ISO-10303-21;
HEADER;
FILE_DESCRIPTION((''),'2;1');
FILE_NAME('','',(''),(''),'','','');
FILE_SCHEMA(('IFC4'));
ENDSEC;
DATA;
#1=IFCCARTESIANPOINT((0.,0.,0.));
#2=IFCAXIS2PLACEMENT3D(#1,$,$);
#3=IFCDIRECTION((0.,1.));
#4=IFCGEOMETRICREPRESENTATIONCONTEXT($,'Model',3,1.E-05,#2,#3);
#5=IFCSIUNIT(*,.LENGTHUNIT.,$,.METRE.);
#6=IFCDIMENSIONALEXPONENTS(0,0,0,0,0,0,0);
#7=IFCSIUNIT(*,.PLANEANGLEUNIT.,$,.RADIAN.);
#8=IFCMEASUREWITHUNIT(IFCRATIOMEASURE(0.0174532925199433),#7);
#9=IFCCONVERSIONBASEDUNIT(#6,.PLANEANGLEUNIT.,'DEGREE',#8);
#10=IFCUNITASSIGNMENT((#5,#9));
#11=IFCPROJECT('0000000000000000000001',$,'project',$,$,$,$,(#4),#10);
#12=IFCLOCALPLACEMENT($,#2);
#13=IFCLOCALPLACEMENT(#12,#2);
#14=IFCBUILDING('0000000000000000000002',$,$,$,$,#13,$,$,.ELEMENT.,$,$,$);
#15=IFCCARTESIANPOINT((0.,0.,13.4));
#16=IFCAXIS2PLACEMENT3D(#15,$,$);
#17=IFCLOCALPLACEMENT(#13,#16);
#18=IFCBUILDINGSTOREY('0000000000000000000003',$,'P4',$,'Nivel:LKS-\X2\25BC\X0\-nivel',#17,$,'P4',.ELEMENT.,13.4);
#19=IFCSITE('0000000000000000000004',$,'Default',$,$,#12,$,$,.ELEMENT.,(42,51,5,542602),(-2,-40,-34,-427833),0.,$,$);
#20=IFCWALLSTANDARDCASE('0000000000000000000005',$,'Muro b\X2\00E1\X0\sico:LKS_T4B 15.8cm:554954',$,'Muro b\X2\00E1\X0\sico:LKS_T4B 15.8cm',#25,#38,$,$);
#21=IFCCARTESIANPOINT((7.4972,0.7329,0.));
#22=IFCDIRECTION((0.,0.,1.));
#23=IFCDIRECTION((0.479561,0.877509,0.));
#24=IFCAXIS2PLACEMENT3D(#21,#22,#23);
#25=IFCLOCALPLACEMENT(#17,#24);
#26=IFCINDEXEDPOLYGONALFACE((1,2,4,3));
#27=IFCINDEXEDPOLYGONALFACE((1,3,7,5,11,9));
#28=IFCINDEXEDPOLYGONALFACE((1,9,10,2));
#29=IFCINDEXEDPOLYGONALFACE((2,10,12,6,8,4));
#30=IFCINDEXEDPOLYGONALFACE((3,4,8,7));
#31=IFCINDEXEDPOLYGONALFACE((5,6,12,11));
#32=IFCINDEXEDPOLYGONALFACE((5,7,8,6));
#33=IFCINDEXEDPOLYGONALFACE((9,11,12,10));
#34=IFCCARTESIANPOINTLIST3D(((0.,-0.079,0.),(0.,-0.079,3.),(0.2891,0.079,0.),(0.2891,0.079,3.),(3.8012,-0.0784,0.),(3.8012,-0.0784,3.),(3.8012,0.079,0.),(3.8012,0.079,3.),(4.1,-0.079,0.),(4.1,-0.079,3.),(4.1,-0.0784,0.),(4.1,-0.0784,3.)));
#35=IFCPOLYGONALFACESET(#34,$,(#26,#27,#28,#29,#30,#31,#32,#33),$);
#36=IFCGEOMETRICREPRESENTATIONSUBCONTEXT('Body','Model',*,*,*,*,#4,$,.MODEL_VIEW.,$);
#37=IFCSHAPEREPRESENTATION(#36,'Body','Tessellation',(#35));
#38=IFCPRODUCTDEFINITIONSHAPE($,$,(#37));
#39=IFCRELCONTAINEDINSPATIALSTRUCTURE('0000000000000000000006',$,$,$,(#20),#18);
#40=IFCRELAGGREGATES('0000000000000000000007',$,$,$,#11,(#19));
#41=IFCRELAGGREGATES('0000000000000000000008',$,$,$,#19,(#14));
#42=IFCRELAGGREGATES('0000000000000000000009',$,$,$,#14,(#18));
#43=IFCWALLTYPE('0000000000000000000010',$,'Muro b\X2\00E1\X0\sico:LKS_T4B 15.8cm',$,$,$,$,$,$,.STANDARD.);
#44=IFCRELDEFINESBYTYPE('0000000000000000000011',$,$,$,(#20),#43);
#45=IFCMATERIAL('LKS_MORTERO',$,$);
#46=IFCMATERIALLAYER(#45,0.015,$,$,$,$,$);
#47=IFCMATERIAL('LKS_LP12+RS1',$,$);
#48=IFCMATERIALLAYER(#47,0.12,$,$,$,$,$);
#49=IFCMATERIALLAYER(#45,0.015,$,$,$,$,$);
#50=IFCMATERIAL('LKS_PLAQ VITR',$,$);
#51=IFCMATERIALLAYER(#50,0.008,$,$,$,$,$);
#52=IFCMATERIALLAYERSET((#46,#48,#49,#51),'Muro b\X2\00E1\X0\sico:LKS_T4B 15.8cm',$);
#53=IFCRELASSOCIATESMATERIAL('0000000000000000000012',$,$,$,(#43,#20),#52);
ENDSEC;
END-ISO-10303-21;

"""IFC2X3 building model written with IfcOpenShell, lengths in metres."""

from ifc_helpers import new_model, entity, si_unit, converted_unit, direction, frame, origin, place, context, subcontext, project, spatial, polyline, outline, extrude, clip, bounded_halfspace, material, layer, layer_set, layer_usage, type_object, element, save


model = new_model("IFC2X3")

# Units and contexts
model_context = context("Model", 3, precision=1e-05, world=origin(), true_north=direction((0.0, 1.0)))
body_context = subcontext(model_context, "Body", "Model", "MODEL_VIEW")
ifc_project = project(units=[si_unit("LENGTHUNIT", "METRE"), converted_unit("PLANEANGLEUNIT", "DEGREE", entity("IfcRatioMeasure", 0.0174532925199433), si_unit("PLANEANGLEUNIT", "RADIAN"), dimensions=[0, 0, 0, 0, 0, 0, 0])], contexts=[model_context])

# Site, building, storey
site_placement = place(None, origin())
site = spatial("IfcSite", under=ifc_project, at=site_placement, Name="Default", CompositionType="ELEMENT", RefLatitude=(42, 51, 5, 542602), RefLongitude=(-2, -40, -34, -427833), RefElevation=0.0)
building_placement = place(site_placement, origin())
building = spatial("IfcBuilding", under=site, at=building_placement, CompositionType="ELEMENT")
storey_placement = place(building_placement, frame((0.0, 0.0, 13.4)))
storey = spatial("IfcBuildingStorey", under=building, at=storey_placement, Name="P4", ObjectType="Nivel:LKS-▼-nivel", LongName="P4", CompositionType="ELEMENT", Elevation=13.4)

# Wall
ifc_material_1 = material(Name="LKS_MORTERO")
ifc_layer_1 = layer(ifc_material_1, 0.015)
ifc_material_2 = material(Name="LKS_LP12+RS1")
ifc_layer_2 = layer(ifc_material_2, 0.12)
ifc_layer_3 = layer(ifc_material_1, 0.015)
ifc_material_3 = material(Name="LKS_PLAQ VITR")
ifc_layer_4 = layer(ifc_material_3, 0.008)
ifc_layer_set_1 = layer_set([ifc_layer_1, ifc_layer_2, ifc_layer_3, ifc_layer_4], Name="Muro básico:LKS_T4B 15.8cm")
ifc_layer_usage_1 = layer_usage(ifc_layer_set_1, "AXIS2", "POSITIVE", -0.079)
wall_type_1 = type_object("IfcWallType", Name="Muro básico:LKS_T4B 15.8cm", PredefinedType="STANDARD", material=ifc_layer_set_1)
wall_1_placement = place(storey_placement, frame((7.4972, 0.7329, 0.0), z_axis=(0.0, 0.0, 1.0), x_axis=(0.479561, 0.877509, 0.0)))
element("IfcWallStandardCase", 1, at=wall_1_placement, inside=storey, type_object=wall_type_1, material=ifc_layer_usage_1, Name="Muro básico:LKS_T4B 15.8cm:554954", ObjectType="Muro básico:LKS_T4B 15.8cm", context=body_context, shape_type="Clipping", body=[
    clip(clip(extrude(outline(polyline([(4.1, -0.079), (4.1, -0.0784), (3.8012, -0.0784), (3.8012, 0.079), (1.5591, 0.079), (1.4591, 0.079), (0.2891, 0.079), (0.0, -0.079), (4.1, -0.079)])), origin(), (0.0, 0.0, 1.0), 3.0), bounded_halfspace(frame((3.8012, -0.0784, 0.0), z_axis=(0.0, -1.0, 0.0), x_axis=(0.0, 0.0, -1.0)), True, frame((3.8012, -0.0784, 0.0), z_axis=(0.0, -1.0, 0.0), x_axis=(0.0, 0.0, -1.0)), polyline([(0.0, 0.0), (0.0, 0.2988), (-3.0, 0.2988), (-3.0, 0.0), (0.0, 0.0)]))), bounded_halfspace(frame((3.8012, -0.0784, 3.0), z_axis=(-1.0, 0.0, 0.0), x_axis=(0.0, 0.0, -1.0)), True, frame((3.8012, -0.0784, 3.0), z_axis=(-1.0, 0.0, 0.0), x_axis=(0.0, 0.0, -1.0)), polyline([(0.0, 0.0), (0.0, -0.048), (0.0, -0.1574), (3.0, -0.1574), (3.0, 0.0), (0.0, 0.0)]))),
])

save(model, "model.ifc")
